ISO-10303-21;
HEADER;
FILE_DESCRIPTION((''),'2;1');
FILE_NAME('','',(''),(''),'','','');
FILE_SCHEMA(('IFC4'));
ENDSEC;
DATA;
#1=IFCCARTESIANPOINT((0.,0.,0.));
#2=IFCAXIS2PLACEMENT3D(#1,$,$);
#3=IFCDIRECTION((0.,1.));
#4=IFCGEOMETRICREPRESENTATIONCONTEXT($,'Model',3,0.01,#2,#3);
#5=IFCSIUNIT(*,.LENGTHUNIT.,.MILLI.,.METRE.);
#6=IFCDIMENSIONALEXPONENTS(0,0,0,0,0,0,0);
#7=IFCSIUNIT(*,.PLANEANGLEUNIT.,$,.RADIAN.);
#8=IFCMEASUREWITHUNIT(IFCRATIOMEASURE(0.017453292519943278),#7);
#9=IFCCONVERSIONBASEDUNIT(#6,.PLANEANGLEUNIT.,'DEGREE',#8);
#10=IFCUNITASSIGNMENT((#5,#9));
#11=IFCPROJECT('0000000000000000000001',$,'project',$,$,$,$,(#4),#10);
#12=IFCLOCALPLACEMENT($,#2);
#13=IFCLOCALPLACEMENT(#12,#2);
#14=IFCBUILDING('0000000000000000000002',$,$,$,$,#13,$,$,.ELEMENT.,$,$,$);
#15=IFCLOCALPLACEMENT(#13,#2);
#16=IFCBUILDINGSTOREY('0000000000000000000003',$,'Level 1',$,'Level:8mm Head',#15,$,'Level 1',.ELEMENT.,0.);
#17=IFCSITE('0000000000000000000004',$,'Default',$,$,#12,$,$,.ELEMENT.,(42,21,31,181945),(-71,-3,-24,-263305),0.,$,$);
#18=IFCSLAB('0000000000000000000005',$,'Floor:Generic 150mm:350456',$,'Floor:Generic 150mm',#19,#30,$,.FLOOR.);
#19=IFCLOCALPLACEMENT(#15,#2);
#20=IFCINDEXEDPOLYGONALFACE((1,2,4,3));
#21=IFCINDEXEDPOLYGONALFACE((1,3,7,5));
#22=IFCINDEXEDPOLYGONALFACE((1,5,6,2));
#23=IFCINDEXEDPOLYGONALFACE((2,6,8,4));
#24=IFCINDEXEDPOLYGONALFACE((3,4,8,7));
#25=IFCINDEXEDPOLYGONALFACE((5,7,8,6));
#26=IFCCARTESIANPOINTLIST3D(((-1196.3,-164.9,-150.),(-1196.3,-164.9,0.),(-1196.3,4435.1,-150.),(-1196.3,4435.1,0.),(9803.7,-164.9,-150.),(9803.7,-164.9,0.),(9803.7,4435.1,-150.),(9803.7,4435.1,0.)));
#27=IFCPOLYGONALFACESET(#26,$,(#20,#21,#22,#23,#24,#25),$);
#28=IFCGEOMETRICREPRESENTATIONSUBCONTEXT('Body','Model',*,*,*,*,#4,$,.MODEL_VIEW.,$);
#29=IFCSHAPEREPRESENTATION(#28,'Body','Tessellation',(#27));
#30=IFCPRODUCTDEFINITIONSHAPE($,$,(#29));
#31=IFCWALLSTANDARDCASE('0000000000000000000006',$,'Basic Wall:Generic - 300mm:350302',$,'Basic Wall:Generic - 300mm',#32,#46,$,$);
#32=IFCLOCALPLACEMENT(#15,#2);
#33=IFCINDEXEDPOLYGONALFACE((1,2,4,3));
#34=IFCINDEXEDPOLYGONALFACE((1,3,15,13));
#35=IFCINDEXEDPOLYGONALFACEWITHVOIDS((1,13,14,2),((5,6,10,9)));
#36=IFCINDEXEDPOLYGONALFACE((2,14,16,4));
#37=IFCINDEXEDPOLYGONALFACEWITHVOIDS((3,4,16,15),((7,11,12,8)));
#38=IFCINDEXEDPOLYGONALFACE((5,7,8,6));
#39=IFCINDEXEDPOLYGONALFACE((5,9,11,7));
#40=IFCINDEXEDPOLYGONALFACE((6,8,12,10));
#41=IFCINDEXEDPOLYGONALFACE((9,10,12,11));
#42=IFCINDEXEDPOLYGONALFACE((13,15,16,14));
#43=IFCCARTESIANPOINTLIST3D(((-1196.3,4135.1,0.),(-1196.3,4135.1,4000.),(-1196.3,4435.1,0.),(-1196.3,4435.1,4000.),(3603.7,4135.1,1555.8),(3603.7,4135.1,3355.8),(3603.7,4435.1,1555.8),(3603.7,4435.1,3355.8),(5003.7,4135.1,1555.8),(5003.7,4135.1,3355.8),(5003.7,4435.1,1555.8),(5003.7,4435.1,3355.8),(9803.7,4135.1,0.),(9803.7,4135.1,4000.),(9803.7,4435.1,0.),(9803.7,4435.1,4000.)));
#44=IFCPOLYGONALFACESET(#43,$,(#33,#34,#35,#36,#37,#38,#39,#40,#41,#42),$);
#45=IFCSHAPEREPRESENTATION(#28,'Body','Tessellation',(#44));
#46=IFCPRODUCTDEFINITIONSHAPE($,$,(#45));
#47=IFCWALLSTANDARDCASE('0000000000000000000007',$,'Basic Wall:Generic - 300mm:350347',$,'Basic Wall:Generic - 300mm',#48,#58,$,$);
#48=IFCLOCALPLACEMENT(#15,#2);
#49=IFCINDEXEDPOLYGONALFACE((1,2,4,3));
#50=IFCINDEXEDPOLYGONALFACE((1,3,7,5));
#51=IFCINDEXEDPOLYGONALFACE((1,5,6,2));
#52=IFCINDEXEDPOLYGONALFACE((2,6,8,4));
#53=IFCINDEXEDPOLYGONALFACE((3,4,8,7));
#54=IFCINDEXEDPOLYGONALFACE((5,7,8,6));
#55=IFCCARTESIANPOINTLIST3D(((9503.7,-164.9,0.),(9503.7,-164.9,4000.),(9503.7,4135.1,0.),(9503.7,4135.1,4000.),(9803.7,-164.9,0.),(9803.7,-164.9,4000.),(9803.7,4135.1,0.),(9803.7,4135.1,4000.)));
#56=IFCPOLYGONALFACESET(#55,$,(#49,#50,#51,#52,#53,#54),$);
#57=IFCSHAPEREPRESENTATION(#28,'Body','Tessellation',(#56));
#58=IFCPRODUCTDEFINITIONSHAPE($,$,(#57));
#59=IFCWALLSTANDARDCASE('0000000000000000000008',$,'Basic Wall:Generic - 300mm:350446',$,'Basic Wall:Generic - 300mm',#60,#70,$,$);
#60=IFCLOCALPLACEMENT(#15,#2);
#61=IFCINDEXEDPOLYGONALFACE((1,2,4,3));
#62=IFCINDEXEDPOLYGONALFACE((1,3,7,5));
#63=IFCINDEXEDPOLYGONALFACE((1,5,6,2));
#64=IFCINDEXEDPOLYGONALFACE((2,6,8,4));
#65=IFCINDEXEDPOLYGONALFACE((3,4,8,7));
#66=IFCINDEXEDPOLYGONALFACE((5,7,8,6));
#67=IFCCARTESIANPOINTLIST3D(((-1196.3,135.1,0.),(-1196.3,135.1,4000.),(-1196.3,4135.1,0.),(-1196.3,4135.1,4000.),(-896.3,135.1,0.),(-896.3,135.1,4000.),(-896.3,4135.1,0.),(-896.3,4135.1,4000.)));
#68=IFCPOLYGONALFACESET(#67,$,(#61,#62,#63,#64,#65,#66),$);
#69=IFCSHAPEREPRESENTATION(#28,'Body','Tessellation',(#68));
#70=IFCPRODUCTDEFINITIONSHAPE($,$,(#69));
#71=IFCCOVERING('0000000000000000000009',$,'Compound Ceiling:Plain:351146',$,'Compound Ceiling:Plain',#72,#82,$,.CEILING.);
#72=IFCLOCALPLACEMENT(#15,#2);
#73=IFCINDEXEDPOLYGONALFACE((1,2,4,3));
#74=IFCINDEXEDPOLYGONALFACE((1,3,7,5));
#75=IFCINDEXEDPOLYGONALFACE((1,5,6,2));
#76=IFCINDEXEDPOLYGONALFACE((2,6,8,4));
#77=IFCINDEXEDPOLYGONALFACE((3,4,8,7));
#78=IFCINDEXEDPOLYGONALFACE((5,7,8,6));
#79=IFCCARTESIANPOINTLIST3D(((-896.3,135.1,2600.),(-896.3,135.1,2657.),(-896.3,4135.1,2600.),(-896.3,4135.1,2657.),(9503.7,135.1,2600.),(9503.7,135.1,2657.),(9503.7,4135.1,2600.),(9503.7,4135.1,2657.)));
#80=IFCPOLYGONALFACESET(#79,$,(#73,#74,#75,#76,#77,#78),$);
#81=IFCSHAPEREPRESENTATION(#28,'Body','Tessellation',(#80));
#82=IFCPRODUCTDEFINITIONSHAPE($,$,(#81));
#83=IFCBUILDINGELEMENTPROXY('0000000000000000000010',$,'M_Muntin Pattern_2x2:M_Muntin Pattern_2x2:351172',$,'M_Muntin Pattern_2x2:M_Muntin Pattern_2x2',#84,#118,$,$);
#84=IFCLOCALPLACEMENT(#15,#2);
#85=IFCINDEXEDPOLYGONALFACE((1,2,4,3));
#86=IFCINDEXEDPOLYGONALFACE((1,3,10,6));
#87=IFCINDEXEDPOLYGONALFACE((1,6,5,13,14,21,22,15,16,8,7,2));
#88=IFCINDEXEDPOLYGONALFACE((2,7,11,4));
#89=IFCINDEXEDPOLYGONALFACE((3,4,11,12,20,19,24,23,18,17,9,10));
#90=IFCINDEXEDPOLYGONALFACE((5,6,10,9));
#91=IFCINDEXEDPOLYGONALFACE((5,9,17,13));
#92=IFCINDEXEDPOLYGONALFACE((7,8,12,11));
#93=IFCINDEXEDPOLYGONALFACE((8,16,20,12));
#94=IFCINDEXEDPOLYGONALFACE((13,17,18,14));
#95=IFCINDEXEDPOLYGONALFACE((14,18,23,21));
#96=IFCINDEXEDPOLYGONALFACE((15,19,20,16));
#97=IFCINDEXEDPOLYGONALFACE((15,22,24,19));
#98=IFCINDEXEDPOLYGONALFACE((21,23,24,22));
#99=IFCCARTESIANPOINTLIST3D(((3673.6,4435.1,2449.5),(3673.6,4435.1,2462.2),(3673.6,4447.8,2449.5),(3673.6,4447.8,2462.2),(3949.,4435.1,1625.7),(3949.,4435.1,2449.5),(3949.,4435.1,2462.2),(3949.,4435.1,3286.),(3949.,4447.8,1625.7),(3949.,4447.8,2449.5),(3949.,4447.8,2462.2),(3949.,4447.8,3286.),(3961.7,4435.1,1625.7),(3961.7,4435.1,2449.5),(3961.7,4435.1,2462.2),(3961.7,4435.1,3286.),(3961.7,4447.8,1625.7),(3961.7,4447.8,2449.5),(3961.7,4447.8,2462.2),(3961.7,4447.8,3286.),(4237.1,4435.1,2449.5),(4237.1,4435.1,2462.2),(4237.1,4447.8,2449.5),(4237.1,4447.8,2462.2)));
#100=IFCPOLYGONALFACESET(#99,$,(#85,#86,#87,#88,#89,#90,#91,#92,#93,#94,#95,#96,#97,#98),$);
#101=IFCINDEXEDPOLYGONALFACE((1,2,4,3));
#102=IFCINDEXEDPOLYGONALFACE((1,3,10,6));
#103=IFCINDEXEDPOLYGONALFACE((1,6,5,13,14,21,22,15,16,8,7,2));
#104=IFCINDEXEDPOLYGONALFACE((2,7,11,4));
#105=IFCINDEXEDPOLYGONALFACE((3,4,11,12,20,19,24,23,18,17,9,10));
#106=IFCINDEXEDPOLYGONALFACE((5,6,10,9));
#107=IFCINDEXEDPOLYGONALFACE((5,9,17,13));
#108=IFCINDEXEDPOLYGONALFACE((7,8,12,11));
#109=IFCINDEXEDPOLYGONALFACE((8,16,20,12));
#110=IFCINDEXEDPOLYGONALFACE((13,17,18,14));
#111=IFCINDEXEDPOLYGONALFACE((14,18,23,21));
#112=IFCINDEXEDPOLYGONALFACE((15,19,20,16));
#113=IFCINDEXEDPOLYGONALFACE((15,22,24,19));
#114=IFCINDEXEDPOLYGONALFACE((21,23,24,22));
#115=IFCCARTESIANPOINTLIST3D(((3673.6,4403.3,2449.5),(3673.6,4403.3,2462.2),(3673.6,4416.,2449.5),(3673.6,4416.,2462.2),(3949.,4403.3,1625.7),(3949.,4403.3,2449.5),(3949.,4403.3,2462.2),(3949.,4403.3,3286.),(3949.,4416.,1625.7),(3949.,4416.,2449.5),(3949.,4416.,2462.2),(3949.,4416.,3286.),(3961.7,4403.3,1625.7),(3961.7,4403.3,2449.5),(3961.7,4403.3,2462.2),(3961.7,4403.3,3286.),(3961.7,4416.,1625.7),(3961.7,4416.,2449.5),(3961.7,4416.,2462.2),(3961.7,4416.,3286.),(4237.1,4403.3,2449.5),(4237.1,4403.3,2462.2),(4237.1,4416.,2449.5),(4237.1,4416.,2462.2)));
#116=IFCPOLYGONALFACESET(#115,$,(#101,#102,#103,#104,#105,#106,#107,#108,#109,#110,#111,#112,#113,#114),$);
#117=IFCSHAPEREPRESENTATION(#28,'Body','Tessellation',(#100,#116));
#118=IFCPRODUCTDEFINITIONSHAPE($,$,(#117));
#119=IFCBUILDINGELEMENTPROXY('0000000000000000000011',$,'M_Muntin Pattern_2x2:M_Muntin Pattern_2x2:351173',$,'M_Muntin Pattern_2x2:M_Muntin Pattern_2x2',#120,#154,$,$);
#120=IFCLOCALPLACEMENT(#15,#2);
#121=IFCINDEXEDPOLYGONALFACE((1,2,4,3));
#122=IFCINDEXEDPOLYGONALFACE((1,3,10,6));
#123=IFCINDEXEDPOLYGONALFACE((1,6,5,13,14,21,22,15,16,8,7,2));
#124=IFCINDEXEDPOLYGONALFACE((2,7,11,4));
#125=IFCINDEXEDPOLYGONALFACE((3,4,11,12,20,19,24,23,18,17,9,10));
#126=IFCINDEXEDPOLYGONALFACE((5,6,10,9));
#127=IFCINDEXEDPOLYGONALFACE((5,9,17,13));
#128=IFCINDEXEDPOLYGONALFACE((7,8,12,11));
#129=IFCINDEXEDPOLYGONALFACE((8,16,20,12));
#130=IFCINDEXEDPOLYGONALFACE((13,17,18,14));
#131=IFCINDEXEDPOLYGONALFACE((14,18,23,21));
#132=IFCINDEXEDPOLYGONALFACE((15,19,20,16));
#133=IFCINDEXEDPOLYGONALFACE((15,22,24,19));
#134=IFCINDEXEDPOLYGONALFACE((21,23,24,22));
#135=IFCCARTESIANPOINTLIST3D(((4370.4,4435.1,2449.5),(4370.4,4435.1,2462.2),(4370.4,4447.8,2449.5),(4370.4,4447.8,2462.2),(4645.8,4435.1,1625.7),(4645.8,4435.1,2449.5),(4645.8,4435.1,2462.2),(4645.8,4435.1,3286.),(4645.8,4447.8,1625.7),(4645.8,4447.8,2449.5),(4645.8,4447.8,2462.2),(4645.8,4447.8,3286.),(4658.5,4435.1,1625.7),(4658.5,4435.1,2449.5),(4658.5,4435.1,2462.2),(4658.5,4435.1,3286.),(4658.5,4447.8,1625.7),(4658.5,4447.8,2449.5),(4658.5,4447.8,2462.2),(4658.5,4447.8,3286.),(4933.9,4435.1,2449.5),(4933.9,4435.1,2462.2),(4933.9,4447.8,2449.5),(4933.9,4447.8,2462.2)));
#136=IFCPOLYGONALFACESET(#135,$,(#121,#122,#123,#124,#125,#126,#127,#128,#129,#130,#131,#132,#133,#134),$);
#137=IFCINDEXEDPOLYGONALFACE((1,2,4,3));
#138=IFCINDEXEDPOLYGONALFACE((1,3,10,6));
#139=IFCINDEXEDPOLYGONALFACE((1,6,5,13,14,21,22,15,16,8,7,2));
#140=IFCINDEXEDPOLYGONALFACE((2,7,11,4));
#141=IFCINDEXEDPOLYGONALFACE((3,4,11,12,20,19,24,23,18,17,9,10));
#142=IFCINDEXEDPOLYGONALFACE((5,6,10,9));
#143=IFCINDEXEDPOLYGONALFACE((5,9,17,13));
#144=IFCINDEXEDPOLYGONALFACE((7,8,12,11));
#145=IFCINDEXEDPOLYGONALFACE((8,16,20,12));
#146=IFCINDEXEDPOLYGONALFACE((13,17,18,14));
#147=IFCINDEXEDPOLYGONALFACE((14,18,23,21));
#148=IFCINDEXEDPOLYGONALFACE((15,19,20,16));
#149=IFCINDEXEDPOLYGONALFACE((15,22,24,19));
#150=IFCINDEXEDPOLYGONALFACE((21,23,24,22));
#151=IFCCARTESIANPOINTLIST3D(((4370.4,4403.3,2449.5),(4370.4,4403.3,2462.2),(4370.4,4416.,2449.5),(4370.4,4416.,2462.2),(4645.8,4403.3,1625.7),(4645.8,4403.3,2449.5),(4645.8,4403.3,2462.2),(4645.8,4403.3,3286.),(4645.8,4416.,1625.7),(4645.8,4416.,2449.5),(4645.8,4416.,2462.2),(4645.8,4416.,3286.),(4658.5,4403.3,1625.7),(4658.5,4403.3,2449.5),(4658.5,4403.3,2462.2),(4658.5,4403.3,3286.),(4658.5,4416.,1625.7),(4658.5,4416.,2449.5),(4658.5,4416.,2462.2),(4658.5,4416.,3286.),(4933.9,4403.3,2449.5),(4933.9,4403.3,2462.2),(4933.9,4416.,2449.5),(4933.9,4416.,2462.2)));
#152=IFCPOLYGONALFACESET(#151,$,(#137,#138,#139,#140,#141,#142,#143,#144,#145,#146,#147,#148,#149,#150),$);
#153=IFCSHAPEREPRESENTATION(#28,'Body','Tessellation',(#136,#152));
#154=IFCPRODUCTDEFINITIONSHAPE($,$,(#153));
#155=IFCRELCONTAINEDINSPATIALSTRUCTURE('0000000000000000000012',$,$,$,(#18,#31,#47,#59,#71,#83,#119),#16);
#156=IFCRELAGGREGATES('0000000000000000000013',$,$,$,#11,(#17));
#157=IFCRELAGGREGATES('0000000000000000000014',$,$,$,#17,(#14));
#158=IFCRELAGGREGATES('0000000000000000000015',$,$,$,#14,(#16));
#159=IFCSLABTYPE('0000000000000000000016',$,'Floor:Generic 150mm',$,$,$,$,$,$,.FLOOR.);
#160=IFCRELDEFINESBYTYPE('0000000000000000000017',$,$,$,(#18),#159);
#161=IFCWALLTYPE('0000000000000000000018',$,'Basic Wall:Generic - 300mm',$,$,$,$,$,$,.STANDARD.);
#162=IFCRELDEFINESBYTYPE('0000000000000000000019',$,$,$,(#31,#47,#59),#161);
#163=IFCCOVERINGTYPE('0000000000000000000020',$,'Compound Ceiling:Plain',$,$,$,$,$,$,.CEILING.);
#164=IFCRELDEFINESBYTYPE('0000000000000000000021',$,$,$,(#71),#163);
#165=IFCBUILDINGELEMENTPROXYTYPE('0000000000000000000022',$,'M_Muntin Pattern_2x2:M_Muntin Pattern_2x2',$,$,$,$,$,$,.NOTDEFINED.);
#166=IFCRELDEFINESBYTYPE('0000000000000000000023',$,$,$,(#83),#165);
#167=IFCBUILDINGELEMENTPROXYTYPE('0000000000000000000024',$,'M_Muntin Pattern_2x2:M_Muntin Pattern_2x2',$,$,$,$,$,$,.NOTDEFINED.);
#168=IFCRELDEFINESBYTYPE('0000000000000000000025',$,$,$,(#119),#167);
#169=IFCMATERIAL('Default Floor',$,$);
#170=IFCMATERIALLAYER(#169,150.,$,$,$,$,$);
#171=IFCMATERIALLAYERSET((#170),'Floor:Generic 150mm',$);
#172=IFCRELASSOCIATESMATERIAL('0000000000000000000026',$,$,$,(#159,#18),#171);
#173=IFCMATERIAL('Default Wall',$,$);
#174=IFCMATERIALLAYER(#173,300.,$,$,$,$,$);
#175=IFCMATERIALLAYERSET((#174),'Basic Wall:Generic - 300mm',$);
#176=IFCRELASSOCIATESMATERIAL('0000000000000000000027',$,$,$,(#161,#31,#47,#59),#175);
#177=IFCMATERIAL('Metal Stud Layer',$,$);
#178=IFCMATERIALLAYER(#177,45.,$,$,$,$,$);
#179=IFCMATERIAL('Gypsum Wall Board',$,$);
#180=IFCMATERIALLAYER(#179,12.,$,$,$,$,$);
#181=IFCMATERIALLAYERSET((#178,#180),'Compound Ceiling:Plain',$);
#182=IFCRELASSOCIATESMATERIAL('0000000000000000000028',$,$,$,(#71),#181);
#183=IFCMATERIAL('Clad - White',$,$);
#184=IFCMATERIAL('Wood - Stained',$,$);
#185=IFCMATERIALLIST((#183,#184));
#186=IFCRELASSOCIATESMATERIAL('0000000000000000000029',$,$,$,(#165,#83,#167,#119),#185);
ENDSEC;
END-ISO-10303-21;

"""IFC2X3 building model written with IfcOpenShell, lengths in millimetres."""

from ifc_helpers import new_model, entity, si_unit, converted_unit, direction, frame, frame_2d, origin, place, context, subcontext, project, spatial, polyline, rectangle, outline, extrude, source, transform, mapped, material, material_list, layer, layer_set, layer_usage, type_object, type_shapes, element, save


model = new_model("IFC2X3")

# Units and contexts
model_context = context("Model", 3, precision=0.01, world=origin(), true_north=direction((0.0, 1.0)))
body_context = subcontext(model_context, "Body", "Model", "MODEL_VIEW")
ifc_project = project(units=[si_unit("LENGTHUNIT", "METRE", prefix="MILLI"), converted_unit("PLANEANGLEUNIT", "DEGREE", entity("IfcRatioMeasure", 0.017453292519943278), si_unit("PLANEANGLEUNIT", "RADIAN"), dimensions=[0, 0, 0, 0, 0, 0, 0])], contexts=[model_context])

# Site, building, storey
site_placement = place(None, origin())
site = spatial("IfcSite", under=ifc_project, at=site_placement, Name="Default", CompositionType="ELEMENT", RefLatitude=(42, 21, 31, 181945), RefLongitude=(-71, -3, -24, -263305), RefElevation=0.0)
building_placement = place(site_placement, origin())
building = spatial("IfcBuilding", under=site, at=building_placement, CompositionType="ELEMENT")
storey_placement = place(building_placement, origin())
storey = spatial("IfcBuildingStorey", under=building, at=storey_placement, Name="Level 1", ObjectType="Level:8mm Head", LongName="Level 1", CompositionType="ELEMENT", Elevation=0.0)

# Slab
ifc_material_1 = material(Name="Default Floor")
ifc_layer_1 = layer(ifc_material_1, 150.0)
ifc_layer_set_1 = layer_set([ifc_layer_1], Name="Floor:Generic 150mm")
ifc_layer_usage_1 = layer_usage(ifc_layer_set_1, "AXIS3", "POSITIVE", 0.0)
slab_type = type_object("IfcSlabType", Name="Floor:Generic 150mm", PredefinedType="FLOOR", material=ifc_layer_set_1)
slab_placement = place(storey_placement, origin())
element("IfcSlab", 1, at=slab_placement, inside=storey, type_object=slab_type, material=ifc_layer_usage_1, Name="Floor:Generic 150mm:350456", ObjectType="Floor:Generic 150mm", PredefinedType="FLOOR", context=body_context, shape_type="SweptSolid", body=[
    extrude(rectangle(XDim=4600.0, YDim=11000.0, at=frame_2d((0.0, 0.0), x_axis=(1.0, 0.0))), frame((4303.7, 2135.1, 0.0), z_axis=(0.0, 0.0, -1.0), x_axis=(0.0, 1.0, 0.0)), (0.0, 0.0, 1.0), 150.0),
])

# Wall, opening
ifc_material_2 = material(Name="Default Wall")
ifc_layer_2 = layer(ifc_material_2, 300.0)
ifc_layer_set_2 = layer_set([ifc_layer_2], Name="Basic Wall:Generic - 300mm")
ifc_layer_usage_2 = layer_usage(ifc_layer_set_2, "AXIS2", "NEGATIVE", 150.0)
wall_type = type_object("IfcWallType", Name="Basic Wall:Generic - 300mm", PredefinedType="STANDARD", material=ifc_layer_set_2)
wall_1_placement = place(storey_placement, frame((-1196.3, 4285.1, 0.0)))
wall_1 = element("IfcWallStandardCase", 2, at=wall_1_placement, inside=storey, type_object=wall_type, material=ifc_layer_usage_2, Name="Basic Wall:Generic - 300mm:350302", ObjectType="Basic Wall:Generic - 300mm", context=body_context, shape_type="SweptSolid", body=[
    extrude(rectangle(XDim=11000.0, YDim=300.0, at=frame_2d((5500.0, 0.0), x_axis=(-1.0, 0.0))), origin(), (0.0, 0.0, 1.0), 4000.0),
])
opening_1_placement = place(wall_1_placement, frame((4800.0, -150.0, 1555.8)))
element("IfcOpeningElement", 3, at=opening_1_placement, cuts=wall_1, ObjectType="Opening", context=body_context, shape_type="SweptSolid", body=[
    extrude(rectangle(XDim=1800.0, YDim=1400.0, at=frame_2d((900.0, 700.0), x_axis=(-1.0, 0.0))), frame((0.0, 0.0, 0.0), z_axis=(0.0, 1.0, 0.0), x_axis=(0.0, 0.0, 1.0)), (0.0, 0.0, 1.0), 300.0),
])

# Wall
wall_2_placement = place(storey_placement, frame((9653.7, 4135.1, 0.0), z_axis=(0.0, 0.0, 1.0), x_axis=(0.0, -1.0, 0.0)))
element("IfcWallStandardCase", 4, at=wall_2_placement, inside=storey, type_object=wall_type, material=ifc_layer_usage_2, Name="Basic Wall:Generic - 300mm:350347", ObjectType="Basic Wall:Generic - 300mm", context=body_context, shape_type="SweptSolid", body=[
    extrude(rectangle(XDim=4300.0, YDim=300.0, at=frame_2d((2150.0, 0.0), x_axis=(-1.0, 0.0))), origin(), (0.0, 0.0, 1.0), 4000.0),
])

# Wall
wall_3_placement = place(storey_placement, frame((-1046.3, 135.1, 0.0), z_axis=(0.0, 0.0, 1.0), x_axis=(0.0, 1.0, 0.0)))
element("IfcWallStandardCase", 5, at=wall_3_placement, inside=storey, type_object=wall_type, material=ifc_layer_usage_2, Name="Basic Wall:Generic - 300mm:350446", ObjectType="Basic Wall:Generic - 300mm", context=body_context, shape_type="SweptSolid", body=[
    extrude(rectangle(XDim=4000.0, YDim=300.0, at=frame_2d((2000.0, 0.0), x_axis=(-1.0, 0.0))), origin(), (0.0, 0.0, 1.0), 4000.0),
])

# Covering
ifc_material_3 = material(Name="Metal Stud Layer")
ifc_layer_3 = layer(ifc_material_3, 45.0)
ifc_material_4 = material(Name="Gypsum Wall Board")
ifc_layer_4 = layer(ifc_material_4, 12.0)
ifc_layer_set_3 = layer_set([ifc_layer_3, ifc_layer_4], Name="Compound Ceiling:Plain")
ifc_layer_usage_3 = layer_usage(ifc_layer_set_3, "AXIS3", "POSITIVE", 0.0)
covering_type = type_object("IfcCoveringType", Name="Compound Ceiling:Plain", PredefinedType="CEILING")
covering_placement = place(storey_placement, origin())
element("IfcCovering", 6, at=covering_placement, inside=storey, type_object=covering_type, material=ifc_layer_usage_3, Name="Compound Ceiling:Plain:351146", ObjectType="Compound Ceiling:Plain", PredefinedType="CEILING", context=body_context, shape_type="SweptSolid", body=[
    extrude(rectangle(XDim=4000.0, YDim=10400.0, at=frame_2d((0.0, 0.0), x_axis=(1.0, 0.0))), frame((4303.7, 2135.1, 2600.0), z_axis=(0.0, 0.0, 1.0), x_axis=(0.0, -1.0, 0.0)), (0.0, 0.0, 1.0), 57.0),
])

# Building element proxies
ifc_material_5 = material(Name="Clad - White")
ifc_material_6 = material(Name="Wood - Stained")
ifc_material_list_1 = material_list([ifc_material_5, ifc_material_6])
building_element_proxy_type_1 = type_object("IfcBuildingElementProxyType", Name="M_Muntin Pattern_2x2:M_Muntin Pattern_2x2", PredefinedType="NOTDEFINED", material=ifc_material_list_1)
shared_shape_1 = source(origin(), body_context, "Body", "SweptSolid", [
    extrude(outline(polyline([(6.4, -6.4), (830.1, -6.4), (830.1, 6.3), (6.4, 6.3), (6.4, 281.7), (-6.3, 281.7), (-6.3, 6.3), (-830.2, 6.3), (-830.2, -6.4), (-6.3, -6.4), (-6.3, -281.7), (6.4, -281.7), (6.4, -6.4)])), frame((0.0, 9.5, 830.1), z_axis=(0.0, 1.0, 0.0), x_axis=(0.0, 0.0, 1.0)), (0.0, 0.0, 1.0), 12.7),
    extrude(outline(polyline([(6.4, -6.4), (830.2, -6.4), (830.2, 6.3), (6.4, 6.3), (6.4, 281.7), (-6.3, 281.7), (-6.3, 6.3), (-830.2, 6.3), (-830.2, -6.4), (-6.3, -6.4), (-6.3, -281.7), (6.4, -281.7), (6.4, -6.4)])), frame((0.0, -22.2, 830.2), z_axis=(0.0, 1.0, 0.0), x_axis=(0.0, 0.0, 1.0)), (0.0, 0.0, 1.0), 12.7),
])
type_shapes(building_element_proxy_type_1, [shared_shape_1])
proxy_1_placement = place(storey_placement, frame((3955.3, 4425.5, 1625.7)))
element("IfcBuildingElementProxy", 7, at=proxy_1_placement, inside=storey, type_object=building_element_proxy_type_1, material=ifc_material_list_1, Name="M_Muntin Pattern_2x2:M_Muntin Pattern_2x2:351172", ObjectType="M_Muntin Pattern_2x2:M_Muntin Pattern_2x2", context=body_context, shape_type="MappedRepresentation", body=[
    mapped(shared_shape_1, transform((0.0, 0.0, 0.0), scale=1.0)),
])
building_element_proxy_type_2 = type_object("IfcBuildingElementProxyType", Name="M_Muntin Pattern_2x2:M_Muntin Pattern_2x2", PredefinedType="NOTDEFINED", material=ifc_material_list_1)
shared_shape_2 = source(origin(), body_context, "Body", "SweptSolid", [
    extrude(outline(polyline([(6.4, -6.4), (830.1, -6.4), (830.1, 6.3), (6.4, 6.3), (6.4, 281.7), (-6.3, 281.7), (-6.3, 6.3), (-830.2, 6.3), (-830.2, -6.4), (-6.3, -6.4), (-6.3, -281.7), (6.4, -281.7), (6.4, -6.4)])), frame((0.0, -22.2, 830.1), z_axis=(0.0, 1.0, 0.0), x_axis=(0.0, 0.0, 1.0)), (0.0, 0.0, 1.0), 12.7),
    extrude(outline(polyline([(6.4, -6.4), (830.2, -6.4), (830.2, 6.3), (6.4, 6.3), (6.4, 281.7), (-6.3, 281.7), (-6.3, 6.3), (-830.2, 6.3), (-830.2, -6.4), (-6.3, -6.4), (-6.3, -281.7), (6.4, -281.7), (6.4, -6.4)])), frame((0.0, 9.5, 830.2), z_axis=(0.0, 1.0, 0.0), x_axis=(0.0, 0.0, 1.0)), (0.0, 0.0, 1.0), 12.7),
])
type_shapes(building_element_proxy_type_2, [shared_shape_2])
proxy_2_placement = place(storey_placement, frame((4652.1, 4425.5, 1625.7), z_axis=(0.0, 0.0, 1.0), x_axis=(-1.0, 0.0, 0.0)))
element("IfcBuildingElementProxy", 8, at=proxy_2_placement, inside=storey, type_object=building_element_proxy_type_2, material=ifc_material_list_1, Name="M_Muntin Pattern_2x2:M_Muntin Pattern_2x2:351173", ObjectType="M_Muntin Pattern_2x2:M_Muntin Pattern_2x2", context=body_context, shape_type="MappedRepresentation", body=[
    mapped(shared_shape_2, transform((0.0, 0.0, 0.0), scale=1.0)),
])

save(model, "model.ifc")
